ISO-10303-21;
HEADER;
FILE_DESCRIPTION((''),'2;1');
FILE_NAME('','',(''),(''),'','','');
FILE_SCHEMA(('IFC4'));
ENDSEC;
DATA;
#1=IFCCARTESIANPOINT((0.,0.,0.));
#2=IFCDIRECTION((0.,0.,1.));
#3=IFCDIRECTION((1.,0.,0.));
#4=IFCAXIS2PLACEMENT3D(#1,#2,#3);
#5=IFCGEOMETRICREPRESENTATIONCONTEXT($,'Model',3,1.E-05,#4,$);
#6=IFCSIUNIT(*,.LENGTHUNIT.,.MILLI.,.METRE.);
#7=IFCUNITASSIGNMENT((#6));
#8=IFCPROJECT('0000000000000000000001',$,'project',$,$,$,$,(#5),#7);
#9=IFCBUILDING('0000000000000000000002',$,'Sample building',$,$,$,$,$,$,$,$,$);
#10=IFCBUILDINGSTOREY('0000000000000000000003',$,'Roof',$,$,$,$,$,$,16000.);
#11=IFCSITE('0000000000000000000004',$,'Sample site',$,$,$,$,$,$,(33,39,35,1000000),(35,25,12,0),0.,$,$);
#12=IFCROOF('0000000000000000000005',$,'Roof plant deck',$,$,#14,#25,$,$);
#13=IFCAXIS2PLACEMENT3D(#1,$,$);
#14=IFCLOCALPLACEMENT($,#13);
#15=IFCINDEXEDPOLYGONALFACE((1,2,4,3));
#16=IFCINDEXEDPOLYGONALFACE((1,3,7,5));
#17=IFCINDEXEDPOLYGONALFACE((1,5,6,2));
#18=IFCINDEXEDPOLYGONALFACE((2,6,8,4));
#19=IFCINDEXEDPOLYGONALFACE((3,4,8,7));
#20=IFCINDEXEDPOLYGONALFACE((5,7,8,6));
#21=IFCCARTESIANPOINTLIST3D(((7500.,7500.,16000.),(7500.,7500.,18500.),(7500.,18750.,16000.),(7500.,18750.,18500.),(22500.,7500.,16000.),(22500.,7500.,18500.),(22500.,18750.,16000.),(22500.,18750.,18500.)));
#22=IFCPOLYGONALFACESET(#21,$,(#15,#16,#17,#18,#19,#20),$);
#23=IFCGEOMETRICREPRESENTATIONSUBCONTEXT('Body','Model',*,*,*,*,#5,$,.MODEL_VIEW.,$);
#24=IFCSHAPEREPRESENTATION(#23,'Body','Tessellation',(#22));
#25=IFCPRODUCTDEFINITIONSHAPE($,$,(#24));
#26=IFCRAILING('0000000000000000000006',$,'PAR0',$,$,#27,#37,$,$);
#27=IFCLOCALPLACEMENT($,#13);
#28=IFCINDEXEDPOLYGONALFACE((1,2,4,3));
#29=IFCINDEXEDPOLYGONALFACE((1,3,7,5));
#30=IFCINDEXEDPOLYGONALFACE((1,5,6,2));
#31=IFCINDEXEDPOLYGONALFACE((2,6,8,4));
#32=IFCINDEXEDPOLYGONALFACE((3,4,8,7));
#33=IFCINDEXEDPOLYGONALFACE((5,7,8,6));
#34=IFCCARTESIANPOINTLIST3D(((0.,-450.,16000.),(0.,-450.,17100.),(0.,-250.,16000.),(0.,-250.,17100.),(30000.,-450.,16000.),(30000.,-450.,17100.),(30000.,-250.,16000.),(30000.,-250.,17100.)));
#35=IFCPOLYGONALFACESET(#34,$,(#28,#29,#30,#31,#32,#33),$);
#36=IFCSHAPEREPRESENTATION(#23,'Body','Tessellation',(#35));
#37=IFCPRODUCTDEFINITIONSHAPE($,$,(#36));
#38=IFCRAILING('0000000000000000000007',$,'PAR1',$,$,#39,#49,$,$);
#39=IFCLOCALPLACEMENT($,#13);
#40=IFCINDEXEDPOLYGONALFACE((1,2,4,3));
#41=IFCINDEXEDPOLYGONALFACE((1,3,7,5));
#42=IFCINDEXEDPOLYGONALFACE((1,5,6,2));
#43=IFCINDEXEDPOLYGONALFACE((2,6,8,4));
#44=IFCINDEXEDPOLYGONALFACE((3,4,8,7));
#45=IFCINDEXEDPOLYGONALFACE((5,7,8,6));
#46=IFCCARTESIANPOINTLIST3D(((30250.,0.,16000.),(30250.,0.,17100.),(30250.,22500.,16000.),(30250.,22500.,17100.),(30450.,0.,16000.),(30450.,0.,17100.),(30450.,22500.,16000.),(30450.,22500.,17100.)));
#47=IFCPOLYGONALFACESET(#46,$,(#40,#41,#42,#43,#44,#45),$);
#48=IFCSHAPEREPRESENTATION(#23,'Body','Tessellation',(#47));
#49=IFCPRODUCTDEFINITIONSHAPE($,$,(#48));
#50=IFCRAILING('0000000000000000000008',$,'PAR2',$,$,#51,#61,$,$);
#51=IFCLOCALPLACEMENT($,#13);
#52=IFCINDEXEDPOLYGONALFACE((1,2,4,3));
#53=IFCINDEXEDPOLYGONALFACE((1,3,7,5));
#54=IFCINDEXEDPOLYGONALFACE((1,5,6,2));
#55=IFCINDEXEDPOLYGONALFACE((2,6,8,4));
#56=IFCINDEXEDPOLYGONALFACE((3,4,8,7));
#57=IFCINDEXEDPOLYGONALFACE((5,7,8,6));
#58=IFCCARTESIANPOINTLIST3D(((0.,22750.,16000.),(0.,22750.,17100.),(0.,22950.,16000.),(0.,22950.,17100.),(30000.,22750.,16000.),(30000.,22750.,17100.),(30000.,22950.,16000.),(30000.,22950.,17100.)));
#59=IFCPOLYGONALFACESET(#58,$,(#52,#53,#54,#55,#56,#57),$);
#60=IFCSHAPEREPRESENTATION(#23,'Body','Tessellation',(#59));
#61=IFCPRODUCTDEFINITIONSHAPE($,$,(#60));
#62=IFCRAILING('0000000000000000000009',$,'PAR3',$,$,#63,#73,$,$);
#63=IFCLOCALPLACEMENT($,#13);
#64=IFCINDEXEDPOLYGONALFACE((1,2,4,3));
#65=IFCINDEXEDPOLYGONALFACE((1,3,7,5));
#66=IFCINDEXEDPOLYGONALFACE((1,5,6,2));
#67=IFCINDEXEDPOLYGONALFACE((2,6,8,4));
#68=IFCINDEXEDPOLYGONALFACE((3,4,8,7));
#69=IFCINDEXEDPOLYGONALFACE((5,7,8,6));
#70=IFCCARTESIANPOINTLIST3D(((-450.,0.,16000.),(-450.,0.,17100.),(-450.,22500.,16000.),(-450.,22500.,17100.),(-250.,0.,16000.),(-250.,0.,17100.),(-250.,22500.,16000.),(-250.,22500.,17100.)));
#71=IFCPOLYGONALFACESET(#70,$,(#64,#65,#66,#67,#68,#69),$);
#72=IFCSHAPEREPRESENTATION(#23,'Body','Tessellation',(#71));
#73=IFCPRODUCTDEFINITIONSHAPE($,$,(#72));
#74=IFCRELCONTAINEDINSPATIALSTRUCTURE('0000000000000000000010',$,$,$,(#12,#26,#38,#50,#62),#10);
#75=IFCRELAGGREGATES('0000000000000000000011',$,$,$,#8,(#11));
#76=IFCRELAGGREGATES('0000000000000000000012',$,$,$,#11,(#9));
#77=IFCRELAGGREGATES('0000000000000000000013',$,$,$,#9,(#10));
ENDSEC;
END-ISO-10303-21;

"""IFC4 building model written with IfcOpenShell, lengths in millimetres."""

from ifc_helpers import new_model, si_unit, frame, origin_with_axes, place, context, subcontext, project, spatial, indexed_curve, outline, extrude, element, save


model = new_model("IFC4")

# Units and contexts
model_context = context("Model", 3, precision=1e-05, world=origin_with_axes())
body_context = subcontext(model_context, "Body", "Model", "MODEL_VIEW")
ifc_project = project(units=[si_unit("LENGTHUNIT", "METRE", prefix="MILLI")], contexts=[model_context])

# Site, building, storey
site = spatial("IfcSite", under=ifc_project, Name="Sample site", RefLatitude=(33, 39, 35, 1000000), RefLongitude=(35, 25, 12, 0), RefElevation=0.0)
building = spatial("IfcBuilding", under=site, Name="Sample building")
storey = spatial("IfcBuildingStorey", under=building, Name="Roof", Elevation=16000.0)

# Roof
roof_placement = place(None, frame((7500.0, 7500.0, 16000.0), z_axis=(0.0, 0.0, 1.0), x_axis=(1.0, 0.0, 0.0)))
element("IfcRoof", 1, at=roof_placement, inside=storey, Name="Roof plant deck", context=body_context, shape_type="SweptSolid", body=[
    extrude(outline(indexed_curve([(0.0, 0.0), (0.0, 11250.0), (15000.0, 11250.0), (15000.0, 0.0), (0.0, 0.0)], self_intersect=False)), origin_with_axes(), (0.0, 0.0, 1.0), 2500.0),
])

# Railings
railing_1_placement = place(None, frame((0.0, -450.0, 16000.0), z_axis=(0.0, 0.0, 1.0), x_axis=(1.0, 0.0, 0.0)))
element("IfcRailing", 2, at=railing_1_placement, inside=storey, Name="PAR0", context=body_context, shape_type="SweptSolid", body=[
    extrude(outline(indexed_curve([(0.0, 0.0), (0.0, 200.0), (30000.0, 200.0), (30000.0, 0.0), (0.0, 0.0)], self_intersect=False)), origin_with_axes(), (0.0, 0.0, 1.0), 1100.0),
])
railing_2_placement = place(None, frame((30450.0, 0.0, 16000.0), z_axis=(0.0, 0.0, 1.0), x_axis=(0.0, 1.0, 0.0)))
element("IfcRailing", 3, at=railing_2_placement, inside=storey, Name="PAR1", context=body_context, shape_type="SweptSolid", body=[
    extrude(outline(indexed_curve([(0.0, 0.0), (0.0, 200.0), (22500.0, 200.0), (22500.0, 0.0), (0.0, 0.0)], self_intersect=False)), origin_with_axes(), (0.0, 0.0, 1.0), 1100.0),
])
railing_3_placement = place(None, frame((30000.0, 22950.0, 16000.0), z_axis=(0.0, 0.0, 1.0), x_axis=(-1.0, 0.0, 0.0)))
element("IfcRailing", 4, at=railing_3_placement, inside=storey, Name="PAR2", context=body_context, shape_type="SweptSolid", body=[
    extrude(outline(indexed_curve([(0.0, 0.0), (0.0, 200.0), (30000.0, 200.0), (30000.0, 0.0), (0.0, 0.0)], self_intersect=False)), origin_with_axes(), (0.0, 0.0, 1.0), 1100.0),
])
railing_4_placement = place(None, frame((-450.0, 22500.0, 16000.0), z_axis=(0.0, 0.0, 1.0), x_axis=(0.0, -1.0, 0.0)))
element("IfcRailing", 5, at=railing_4_placement, inside=storey, Name="PAR3", context=body_context, shape_type="SweptSolid", body=[
    extrude(outline(indexed_curve([(0.0, 0.0), (0.0, 200.0), (22500.0, 200.0), (22500.0, 0.0), (0.0, 0.0)], self_intersect=False)), origin_with_axes(), (0.0, 0.0, 1.0), 1100.0),
])

save(model, "model.ifc")
